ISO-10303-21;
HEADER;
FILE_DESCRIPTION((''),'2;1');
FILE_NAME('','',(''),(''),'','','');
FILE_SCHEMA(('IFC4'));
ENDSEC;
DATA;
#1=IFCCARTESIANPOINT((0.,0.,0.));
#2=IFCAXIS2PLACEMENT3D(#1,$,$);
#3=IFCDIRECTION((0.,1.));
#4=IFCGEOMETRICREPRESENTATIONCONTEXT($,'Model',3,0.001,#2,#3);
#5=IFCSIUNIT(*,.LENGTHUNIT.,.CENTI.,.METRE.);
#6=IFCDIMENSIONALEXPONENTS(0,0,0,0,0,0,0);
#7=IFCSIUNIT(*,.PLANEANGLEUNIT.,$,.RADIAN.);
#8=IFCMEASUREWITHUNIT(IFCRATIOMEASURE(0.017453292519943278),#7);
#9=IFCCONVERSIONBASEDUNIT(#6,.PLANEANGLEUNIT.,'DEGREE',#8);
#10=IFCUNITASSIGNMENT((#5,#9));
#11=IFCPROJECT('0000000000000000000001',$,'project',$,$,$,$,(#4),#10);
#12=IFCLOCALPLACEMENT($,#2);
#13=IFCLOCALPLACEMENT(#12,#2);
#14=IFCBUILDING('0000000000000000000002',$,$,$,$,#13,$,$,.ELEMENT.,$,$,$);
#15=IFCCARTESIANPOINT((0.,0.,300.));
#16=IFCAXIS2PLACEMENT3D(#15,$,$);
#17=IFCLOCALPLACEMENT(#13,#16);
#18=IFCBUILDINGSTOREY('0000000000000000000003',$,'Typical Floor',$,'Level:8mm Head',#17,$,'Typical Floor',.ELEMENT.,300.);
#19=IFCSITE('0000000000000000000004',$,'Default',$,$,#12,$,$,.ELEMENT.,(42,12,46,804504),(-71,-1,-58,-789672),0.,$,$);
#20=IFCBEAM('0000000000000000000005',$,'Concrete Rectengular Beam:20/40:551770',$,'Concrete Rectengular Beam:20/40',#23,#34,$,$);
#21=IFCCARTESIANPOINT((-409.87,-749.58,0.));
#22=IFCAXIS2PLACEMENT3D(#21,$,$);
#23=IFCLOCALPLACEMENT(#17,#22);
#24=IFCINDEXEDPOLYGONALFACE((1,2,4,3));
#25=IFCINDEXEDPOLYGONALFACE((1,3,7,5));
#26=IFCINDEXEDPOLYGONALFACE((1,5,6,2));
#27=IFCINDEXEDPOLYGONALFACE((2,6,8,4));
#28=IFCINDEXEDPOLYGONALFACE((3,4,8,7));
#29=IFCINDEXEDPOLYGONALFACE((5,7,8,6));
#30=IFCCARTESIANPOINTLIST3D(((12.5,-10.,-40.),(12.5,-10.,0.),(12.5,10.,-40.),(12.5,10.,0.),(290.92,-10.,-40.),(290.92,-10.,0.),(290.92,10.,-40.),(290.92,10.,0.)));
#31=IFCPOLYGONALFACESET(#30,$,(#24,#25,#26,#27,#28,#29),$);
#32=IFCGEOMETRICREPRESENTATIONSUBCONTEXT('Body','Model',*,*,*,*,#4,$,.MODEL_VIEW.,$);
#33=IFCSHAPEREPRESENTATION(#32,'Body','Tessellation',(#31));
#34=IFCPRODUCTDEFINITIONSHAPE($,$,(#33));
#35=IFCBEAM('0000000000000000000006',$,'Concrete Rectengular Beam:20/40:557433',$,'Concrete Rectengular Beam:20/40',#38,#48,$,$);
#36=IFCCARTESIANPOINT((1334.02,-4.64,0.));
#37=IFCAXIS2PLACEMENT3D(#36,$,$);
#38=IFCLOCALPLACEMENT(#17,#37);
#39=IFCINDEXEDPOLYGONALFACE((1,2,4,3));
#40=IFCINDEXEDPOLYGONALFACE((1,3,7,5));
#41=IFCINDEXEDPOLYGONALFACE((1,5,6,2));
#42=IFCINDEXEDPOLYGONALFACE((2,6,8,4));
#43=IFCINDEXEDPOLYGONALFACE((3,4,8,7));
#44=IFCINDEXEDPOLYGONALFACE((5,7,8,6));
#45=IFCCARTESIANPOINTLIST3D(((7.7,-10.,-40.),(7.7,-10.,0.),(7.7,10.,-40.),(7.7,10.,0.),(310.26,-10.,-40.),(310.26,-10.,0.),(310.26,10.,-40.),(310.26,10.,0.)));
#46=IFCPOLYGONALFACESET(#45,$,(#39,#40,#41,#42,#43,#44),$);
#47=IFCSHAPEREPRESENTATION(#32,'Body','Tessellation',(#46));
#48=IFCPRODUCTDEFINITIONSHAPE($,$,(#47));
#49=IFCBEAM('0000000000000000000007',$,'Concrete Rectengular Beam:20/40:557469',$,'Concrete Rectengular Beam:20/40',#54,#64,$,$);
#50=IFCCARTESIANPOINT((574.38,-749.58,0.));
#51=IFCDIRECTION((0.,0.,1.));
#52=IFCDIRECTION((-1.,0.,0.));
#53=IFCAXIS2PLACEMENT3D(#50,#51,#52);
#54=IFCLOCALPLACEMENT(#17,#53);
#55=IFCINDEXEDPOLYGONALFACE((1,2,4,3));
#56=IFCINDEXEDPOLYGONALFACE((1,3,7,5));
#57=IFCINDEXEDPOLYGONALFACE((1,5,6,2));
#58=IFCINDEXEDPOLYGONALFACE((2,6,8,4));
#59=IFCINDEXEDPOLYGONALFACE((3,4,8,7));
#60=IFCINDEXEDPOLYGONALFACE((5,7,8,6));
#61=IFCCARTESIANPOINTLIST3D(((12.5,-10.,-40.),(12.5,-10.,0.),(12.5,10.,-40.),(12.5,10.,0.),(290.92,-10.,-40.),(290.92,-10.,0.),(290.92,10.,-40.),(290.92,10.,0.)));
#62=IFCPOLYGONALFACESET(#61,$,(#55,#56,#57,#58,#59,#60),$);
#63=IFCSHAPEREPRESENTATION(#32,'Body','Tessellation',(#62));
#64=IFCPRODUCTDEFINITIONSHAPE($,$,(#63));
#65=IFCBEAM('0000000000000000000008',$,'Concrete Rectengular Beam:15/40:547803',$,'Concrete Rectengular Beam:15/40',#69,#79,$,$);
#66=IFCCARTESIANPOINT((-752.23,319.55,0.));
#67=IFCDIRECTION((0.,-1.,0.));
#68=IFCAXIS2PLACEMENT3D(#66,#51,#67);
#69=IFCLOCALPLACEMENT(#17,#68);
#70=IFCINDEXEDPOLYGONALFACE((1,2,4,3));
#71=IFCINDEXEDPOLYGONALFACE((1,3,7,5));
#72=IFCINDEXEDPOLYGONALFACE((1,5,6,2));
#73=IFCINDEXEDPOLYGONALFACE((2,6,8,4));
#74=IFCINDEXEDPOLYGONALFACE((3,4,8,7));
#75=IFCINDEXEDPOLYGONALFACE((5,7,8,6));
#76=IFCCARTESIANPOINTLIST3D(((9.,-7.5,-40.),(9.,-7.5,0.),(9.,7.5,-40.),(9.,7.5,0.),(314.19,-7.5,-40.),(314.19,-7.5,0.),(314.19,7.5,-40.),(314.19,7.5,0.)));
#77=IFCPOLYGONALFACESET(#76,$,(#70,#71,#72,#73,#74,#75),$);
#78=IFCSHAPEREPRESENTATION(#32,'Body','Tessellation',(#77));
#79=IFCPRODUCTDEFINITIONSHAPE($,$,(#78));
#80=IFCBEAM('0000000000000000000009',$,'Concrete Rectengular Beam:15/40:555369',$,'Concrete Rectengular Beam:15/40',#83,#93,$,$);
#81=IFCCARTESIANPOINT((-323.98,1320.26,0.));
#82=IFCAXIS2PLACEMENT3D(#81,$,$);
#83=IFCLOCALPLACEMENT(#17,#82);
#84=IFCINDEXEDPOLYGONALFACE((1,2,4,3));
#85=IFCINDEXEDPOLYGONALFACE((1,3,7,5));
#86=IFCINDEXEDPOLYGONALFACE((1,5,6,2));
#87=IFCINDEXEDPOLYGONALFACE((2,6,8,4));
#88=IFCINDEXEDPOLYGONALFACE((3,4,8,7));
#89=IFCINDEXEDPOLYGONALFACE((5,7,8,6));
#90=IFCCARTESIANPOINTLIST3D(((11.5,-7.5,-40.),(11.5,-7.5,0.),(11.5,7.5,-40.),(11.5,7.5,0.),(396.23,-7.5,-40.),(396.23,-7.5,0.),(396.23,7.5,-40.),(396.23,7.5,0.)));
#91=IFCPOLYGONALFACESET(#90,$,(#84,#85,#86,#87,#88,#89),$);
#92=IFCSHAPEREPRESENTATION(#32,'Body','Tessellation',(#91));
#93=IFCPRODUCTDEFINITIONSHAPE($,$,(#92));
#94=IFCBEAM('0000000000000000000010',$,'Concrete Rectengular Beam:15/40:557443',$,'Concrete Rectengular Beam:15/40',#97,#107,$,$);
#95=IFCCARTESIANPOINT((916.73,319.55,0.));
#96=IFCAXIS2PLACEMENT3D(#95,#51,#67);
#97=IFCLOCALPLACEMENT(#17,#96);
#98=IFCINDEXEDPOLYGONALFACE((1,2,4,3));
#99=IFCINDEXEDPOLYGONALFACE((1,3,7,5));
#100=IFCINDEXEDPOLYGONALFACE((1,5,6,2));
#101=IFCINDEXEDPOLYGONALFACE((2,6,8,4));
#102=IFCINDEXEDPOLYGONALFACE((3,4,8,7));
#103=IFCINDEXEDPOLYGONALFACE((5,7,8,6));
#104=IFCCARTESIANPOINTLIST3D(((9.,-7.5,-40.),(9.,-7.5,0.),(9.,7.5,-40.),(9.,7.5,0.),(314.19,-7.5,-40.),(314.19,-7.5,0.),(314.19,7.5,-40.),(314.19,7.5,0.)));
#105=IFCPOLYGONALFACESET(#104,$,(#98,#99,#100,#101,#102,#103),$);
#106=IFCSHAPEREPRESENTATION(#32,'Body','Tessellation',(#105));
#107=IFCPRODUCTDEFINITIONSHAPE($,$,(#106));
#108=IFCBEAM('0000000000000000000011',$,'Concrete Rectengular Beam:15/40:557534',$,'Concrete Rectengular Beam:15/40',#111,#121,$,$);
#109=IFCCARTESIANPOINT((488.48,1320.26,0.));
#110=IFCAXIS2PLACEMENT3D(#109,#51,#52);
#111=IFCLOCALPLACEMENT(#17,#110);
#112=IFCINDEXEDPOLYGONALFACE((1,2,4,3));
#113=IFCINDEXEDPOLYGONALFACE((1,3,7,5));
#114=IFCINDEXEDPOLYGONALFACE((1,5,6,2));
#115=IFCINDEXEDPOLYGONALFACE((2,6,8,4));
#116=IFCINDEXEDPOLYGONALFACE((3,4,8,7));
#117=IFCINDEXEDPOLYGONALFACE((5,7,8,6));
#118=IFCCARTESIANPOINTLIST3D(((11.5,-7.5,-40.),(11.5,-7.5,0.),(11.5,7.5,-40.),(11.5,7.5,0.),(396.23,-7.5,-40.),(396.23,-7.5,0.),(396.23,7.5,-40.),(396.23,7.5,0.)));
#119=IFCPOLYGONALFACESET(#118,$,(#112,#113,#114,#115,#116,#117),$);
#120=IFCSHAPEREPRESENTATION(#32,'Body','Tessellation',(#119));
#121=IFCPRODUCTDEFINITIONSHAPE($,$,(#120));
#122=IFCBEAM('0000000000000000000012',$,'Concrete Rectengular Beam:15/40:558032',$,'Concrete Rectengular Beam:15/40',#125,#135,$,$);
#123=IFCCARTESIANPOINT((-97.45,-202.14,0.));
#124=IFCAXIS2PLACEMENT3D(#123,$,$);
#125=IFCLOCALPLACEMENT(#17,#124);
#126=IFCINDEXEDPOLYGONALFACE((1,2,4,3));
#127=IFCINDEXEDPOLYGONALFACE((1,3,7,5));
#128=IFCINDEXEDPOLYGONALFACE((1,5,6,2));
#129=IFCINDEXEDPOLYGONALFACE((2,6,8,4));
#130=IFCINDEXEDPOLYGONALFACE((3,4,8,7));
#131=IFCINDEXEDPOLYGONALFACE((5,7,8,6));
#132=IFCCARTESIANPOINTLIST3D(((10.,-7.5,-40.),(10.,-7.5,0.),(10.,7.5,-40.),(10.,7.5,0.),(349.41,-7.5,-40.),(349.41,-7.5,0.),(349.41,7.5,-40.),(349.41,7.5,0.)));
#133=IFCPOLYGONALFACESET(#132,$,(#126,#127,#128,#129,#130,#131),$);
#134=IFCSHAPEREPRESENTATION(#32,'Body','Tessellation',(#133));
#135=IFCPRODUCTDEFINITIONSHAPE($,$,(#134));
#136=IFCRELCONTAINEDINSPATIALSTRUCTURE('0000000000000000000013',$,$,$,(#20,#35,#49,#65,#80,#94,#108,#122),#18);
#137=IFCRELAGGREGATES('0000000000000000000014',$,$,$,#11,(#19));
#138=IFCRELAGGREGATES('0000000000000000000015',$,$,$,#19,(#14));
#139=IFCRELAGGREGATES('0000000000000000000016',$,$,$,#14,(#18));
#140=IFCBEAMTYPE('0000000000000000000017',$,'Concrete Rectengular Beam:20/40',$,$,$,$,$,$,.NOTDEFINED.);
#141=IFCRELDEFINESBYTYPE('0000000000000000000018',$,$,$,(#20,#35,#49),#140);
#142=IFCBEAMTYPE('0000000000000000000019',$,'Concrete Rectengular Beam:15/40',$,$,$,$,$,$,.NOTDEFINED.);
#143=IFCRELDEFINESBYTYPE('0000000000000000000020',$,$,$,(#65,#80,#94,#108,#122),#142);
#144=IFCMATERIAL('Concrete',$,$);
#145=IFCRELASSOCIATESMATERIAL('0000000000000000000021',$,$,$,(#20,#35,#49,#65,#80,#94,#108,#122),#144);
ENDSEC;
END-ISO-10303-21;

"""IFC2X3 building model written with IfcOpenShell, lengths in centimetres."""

from ifc_helpers import new_model, entity, si_unit, converted_unit, direction, frame, frame_2d, origin, place, context, subcontext, project, spatial, rectangle, extrude, material, type_object, element, save


model = new_model("IFC2X3")

# Units and contexts
model_context = context("Model", 3, precision=0.001, world=origin(), true_north=direction((0.0, 1.0)))
body_context = subcontext(model_context, "Body", "Model", "MODEL_VIEW")
ifc_project = project(units=[si_unit("LENGTHUNIT", "METRE", prefix="CENTI"), converted_unit("PLANEANGLEUNIT", "DEGREE", entity("IfcRatioMeasure", 0.017453292519943278), si_unit("PLANEANGLEUNIT", "RADIAN"), dimensions=[0, 0, 0, 0, 0, 0, 0])], contexts=[model_context])

# Site, building, storey
site_placement = place(None, origin())
site = spatial("IfcSite", under=ifc_project, at=site_placement, Name="Default", CompositionType="ELEMENT", RefLatitude=(42, 12, 46, 804504), RefLongitude=(-71, -1, -58, -789672), RefElevation=0.0)
building_placement = place(site_placement, origin())
building = spatial("IfcBuilding", under=site, at=building_placement, CompositionType="ELEMENT")
storey_placement = place(building_placement, frame((0.0, 0.0, 300.0)))
storey = spatial("IfcBuildingStorey", under=building, at=storey_placement, Name="Typical Floor", ObjectType="Level:8mm Head", LongName="Typical Floor", CompositionType="ELEMENT", Elevation=300.0)

# Beams
ifc_material = material(Name="Concrete")
beam_type_1 = type_object("IfcBeamType", Name="Concrete Rectengular Beam:20/40", PredefinedType="NOTDEFINED")
beam_1_placement = place(storey_placement, frame((-409.87, -749.58, 0.0)))
element("IfcBeam", 1, at=beam_1_placement, inside=storey, type_object=beam_type_1, material=ifc_material, Name="Concrete Rectengular Beam:20/40:551770", ObjectType="Concrete Rectengular Beam:20/40", context=body_context, shape_type="SweptSolid", body=[
    extrude(rectangle(XDim=40.0, YDim=20.0, at=frame_2d((0.0, 0.0), x_axis=(1.0, 0.0))), frame((12.5, 0.0, -20.0), z_axis=(1.0, 0.0, 0.0), x_axis=(0.0, 0.0, -1.0)), (0.0, 0.0, 1.0), 278.42),
])
beam_2_placement = place(storey_placement, frame((1334.02, -4.64, 0.0)))
element("IfcBeam", 2, at=beam_2_placement, inside=storey, type_object=beam_type_1, material=ifc_material, Name="Concrete Rectengular Beam:20/40:557433", ObjectType="Concrete Rectengular Beam:20/40", context=body_context, shape_type="SweptSolid", body=[
    extrude(rectangle(XDim=40.0, YDim=20.0, at=frame_2d((0.0, 0.0), x_axis=(1.0, 0.0))), frame((7.7, 0.0, -20.0), z_axis=(1.0, 0.0, 0.0), x_axis=(0.0, 0.0, -1.0)), (0.0, 0.0, 1.0), 302.56),
])
beam_3_placement = place(storey_placement, frame((574.38, -749.58, 0.0), z_axis=(0.0, 0.0, 1.0), x_axis=(-1.0, 0.0, 0.0)))
element("IfcBeam", 3, at=beam_3_placement, inside=storey, type_object=beam_type_1, material=ifc_material, Name="Concrete Rectengular Beam:20/40:557469", ObjectType="Concrete Rectengular Beam:20/40", context=body_context, shape_type="SweptSolid", body=[
    extrude(rectangle(XDim=40.0, YDim=20.0, at=frame_2d((0.0, 0.0), x_axis=(1.0, 0.0))), frame((12.5, 0.0, -20.0), z_axis=(1.0, 0.0, 0.0), x_axis=(0.0, 0.0, -1.0)), (0.0, 0.0, 1.0), 278.42),
])
beam_type_2 = type_object("IfcBeamType", Name="Concrete Rectengular Beam:15/40", PredefinedType="NOTDEFINED")
beam_4_placement = place(storey_placement, frame((-752.23, 319.55, 0.0), z_axis=(0.0, 0.0, 1.0), x_axis=(0.0, -1.0, 0.0)))
element("IfcBeam", 4, at=beam_4_placement, inside=storey, type_object=beam_type_2, material=ifc_material, Name="Concrete Rectengular Beam:15/40:547803", ObjectType="Concrete Rectengular Beam:15/40", context=body_context, shape_type="SweptSolid", body=[
    extrude(rectangle(XDim=40.0, YDim=15.0, at=frame_2d((0.0, 0.0), x_axis=(1.0, 0.0))), frame((9.0, 0.0, -20.0), z_axis=(1.0, 0.0, 0.0), x_axis=(0.0, 0.0, -1.0)), (0.0, 0.0, 1.0), 305.19),
])
beam_5_placement = place(storey_placement, frame((-323.98, 1320.26, 0.0)))
element("IfcBeam", 5, at=beam_5_placement, inside=storey, type_object=beam_type_2, material=ifc_material, Name="Concrete Rectengular Beam:15/40:555369", ObjectType="Concrete Rectengular Beam:15/40", context=body_context, shape_type="SweptSolid", body=[
    extrude(rectangle(XDim=40.0, YDim=15.0, at=frame_2d((0.0, 0.0), x_axis=(1.0, 0.0))), frame((11.5, 0.0, -20.0), z_axis=(1.0, 0.0, 0.0), x_axis=(0.0, 0.0, -1.0)), (0.0, 0.0, 1.0), 384.73),
])
beam_6_placement = place(storey_placement, frame((916.73, 319.55, 0.0), z_axis=(0.0, 0.0, 1.0), x_axis=(0.0, -1.0, 0.0)))
element("IfcBeam", 6, at=beam_6_placement, inside=storey, type_object=beam_type_2, material=ifc_material, Name="Concrete Rectengular Beam:15/40:557443", ObjectType="Concrete Rectengular Beam:15/40", context=body_context, shape_type="SweptSolid", body=[
    extrude(rectangle(XDim=40.0, YDim=15.0, at=frame_2d((0.0, 0.0), x_axis=(1.0, 0.0))), frame((9.0, 0.0, -20.0), z_axis=(1.0, 0.0, 0.0), x_axis=(0.0, 0.0, -1.0)), (0.0, 0.0, 1.0), 305.19),
])
beam_7_placement = place(storey_placement, frame((488.48, 1320.26, 0.0), z_axis=(0.0, 0.0, 1.0), x_axis=(-1.0, 0.0, 0.0)))
element("IfcBeam", 7, at=beam_7_placement, inside=storey, type_object=beam_type_2, material=ifc_material, Name="Concrete Rectengular Beam:15/40:557534", ObjectType="Concrete Rectengular Beam:15/40", context=body_context, shape_type="SweptSolid", body=[
    extrude(rectangle(XDim=40.0, YDim=15.0, at=frame_2d((0.0, 0.0), x_axis=(1.0, 0.0))), frame((11.5, 0.0, -20.0), z_axis=(1.0, 0.0, 0.0), x_axis=(0.0, 0.0, -1.0)), (0.0, 0.0, 1.0), 384.73),
])
beam_8_placement = place(storey_placement, frame((-97.45, -202.14, 0.0)))
element("IfcBeam", 8, at=beam_8_placement, inside=storey, type_object=beam_type_2, material=ifc_material, Name="Concrete Rectengular Beam:15/40:558032", ObjectType="Concrete Rectengular Beam:15/40", context=body_context, shape_type="SweptSolid", body=[
    extrude(rectangle(XDim=40.0, YDim=15.0, at=frame_2d((0.0, 0.0), x_axis=(1.0, 0.0))), frame((10.0, 0.0, -20.0), z_axis=(1.0, 0.0, 0.0), x_axis=(0.0, 0.0, -1.0)), (0.0, 0.0, 1.0), 339.41),
])

save(model, "model.ifc")
